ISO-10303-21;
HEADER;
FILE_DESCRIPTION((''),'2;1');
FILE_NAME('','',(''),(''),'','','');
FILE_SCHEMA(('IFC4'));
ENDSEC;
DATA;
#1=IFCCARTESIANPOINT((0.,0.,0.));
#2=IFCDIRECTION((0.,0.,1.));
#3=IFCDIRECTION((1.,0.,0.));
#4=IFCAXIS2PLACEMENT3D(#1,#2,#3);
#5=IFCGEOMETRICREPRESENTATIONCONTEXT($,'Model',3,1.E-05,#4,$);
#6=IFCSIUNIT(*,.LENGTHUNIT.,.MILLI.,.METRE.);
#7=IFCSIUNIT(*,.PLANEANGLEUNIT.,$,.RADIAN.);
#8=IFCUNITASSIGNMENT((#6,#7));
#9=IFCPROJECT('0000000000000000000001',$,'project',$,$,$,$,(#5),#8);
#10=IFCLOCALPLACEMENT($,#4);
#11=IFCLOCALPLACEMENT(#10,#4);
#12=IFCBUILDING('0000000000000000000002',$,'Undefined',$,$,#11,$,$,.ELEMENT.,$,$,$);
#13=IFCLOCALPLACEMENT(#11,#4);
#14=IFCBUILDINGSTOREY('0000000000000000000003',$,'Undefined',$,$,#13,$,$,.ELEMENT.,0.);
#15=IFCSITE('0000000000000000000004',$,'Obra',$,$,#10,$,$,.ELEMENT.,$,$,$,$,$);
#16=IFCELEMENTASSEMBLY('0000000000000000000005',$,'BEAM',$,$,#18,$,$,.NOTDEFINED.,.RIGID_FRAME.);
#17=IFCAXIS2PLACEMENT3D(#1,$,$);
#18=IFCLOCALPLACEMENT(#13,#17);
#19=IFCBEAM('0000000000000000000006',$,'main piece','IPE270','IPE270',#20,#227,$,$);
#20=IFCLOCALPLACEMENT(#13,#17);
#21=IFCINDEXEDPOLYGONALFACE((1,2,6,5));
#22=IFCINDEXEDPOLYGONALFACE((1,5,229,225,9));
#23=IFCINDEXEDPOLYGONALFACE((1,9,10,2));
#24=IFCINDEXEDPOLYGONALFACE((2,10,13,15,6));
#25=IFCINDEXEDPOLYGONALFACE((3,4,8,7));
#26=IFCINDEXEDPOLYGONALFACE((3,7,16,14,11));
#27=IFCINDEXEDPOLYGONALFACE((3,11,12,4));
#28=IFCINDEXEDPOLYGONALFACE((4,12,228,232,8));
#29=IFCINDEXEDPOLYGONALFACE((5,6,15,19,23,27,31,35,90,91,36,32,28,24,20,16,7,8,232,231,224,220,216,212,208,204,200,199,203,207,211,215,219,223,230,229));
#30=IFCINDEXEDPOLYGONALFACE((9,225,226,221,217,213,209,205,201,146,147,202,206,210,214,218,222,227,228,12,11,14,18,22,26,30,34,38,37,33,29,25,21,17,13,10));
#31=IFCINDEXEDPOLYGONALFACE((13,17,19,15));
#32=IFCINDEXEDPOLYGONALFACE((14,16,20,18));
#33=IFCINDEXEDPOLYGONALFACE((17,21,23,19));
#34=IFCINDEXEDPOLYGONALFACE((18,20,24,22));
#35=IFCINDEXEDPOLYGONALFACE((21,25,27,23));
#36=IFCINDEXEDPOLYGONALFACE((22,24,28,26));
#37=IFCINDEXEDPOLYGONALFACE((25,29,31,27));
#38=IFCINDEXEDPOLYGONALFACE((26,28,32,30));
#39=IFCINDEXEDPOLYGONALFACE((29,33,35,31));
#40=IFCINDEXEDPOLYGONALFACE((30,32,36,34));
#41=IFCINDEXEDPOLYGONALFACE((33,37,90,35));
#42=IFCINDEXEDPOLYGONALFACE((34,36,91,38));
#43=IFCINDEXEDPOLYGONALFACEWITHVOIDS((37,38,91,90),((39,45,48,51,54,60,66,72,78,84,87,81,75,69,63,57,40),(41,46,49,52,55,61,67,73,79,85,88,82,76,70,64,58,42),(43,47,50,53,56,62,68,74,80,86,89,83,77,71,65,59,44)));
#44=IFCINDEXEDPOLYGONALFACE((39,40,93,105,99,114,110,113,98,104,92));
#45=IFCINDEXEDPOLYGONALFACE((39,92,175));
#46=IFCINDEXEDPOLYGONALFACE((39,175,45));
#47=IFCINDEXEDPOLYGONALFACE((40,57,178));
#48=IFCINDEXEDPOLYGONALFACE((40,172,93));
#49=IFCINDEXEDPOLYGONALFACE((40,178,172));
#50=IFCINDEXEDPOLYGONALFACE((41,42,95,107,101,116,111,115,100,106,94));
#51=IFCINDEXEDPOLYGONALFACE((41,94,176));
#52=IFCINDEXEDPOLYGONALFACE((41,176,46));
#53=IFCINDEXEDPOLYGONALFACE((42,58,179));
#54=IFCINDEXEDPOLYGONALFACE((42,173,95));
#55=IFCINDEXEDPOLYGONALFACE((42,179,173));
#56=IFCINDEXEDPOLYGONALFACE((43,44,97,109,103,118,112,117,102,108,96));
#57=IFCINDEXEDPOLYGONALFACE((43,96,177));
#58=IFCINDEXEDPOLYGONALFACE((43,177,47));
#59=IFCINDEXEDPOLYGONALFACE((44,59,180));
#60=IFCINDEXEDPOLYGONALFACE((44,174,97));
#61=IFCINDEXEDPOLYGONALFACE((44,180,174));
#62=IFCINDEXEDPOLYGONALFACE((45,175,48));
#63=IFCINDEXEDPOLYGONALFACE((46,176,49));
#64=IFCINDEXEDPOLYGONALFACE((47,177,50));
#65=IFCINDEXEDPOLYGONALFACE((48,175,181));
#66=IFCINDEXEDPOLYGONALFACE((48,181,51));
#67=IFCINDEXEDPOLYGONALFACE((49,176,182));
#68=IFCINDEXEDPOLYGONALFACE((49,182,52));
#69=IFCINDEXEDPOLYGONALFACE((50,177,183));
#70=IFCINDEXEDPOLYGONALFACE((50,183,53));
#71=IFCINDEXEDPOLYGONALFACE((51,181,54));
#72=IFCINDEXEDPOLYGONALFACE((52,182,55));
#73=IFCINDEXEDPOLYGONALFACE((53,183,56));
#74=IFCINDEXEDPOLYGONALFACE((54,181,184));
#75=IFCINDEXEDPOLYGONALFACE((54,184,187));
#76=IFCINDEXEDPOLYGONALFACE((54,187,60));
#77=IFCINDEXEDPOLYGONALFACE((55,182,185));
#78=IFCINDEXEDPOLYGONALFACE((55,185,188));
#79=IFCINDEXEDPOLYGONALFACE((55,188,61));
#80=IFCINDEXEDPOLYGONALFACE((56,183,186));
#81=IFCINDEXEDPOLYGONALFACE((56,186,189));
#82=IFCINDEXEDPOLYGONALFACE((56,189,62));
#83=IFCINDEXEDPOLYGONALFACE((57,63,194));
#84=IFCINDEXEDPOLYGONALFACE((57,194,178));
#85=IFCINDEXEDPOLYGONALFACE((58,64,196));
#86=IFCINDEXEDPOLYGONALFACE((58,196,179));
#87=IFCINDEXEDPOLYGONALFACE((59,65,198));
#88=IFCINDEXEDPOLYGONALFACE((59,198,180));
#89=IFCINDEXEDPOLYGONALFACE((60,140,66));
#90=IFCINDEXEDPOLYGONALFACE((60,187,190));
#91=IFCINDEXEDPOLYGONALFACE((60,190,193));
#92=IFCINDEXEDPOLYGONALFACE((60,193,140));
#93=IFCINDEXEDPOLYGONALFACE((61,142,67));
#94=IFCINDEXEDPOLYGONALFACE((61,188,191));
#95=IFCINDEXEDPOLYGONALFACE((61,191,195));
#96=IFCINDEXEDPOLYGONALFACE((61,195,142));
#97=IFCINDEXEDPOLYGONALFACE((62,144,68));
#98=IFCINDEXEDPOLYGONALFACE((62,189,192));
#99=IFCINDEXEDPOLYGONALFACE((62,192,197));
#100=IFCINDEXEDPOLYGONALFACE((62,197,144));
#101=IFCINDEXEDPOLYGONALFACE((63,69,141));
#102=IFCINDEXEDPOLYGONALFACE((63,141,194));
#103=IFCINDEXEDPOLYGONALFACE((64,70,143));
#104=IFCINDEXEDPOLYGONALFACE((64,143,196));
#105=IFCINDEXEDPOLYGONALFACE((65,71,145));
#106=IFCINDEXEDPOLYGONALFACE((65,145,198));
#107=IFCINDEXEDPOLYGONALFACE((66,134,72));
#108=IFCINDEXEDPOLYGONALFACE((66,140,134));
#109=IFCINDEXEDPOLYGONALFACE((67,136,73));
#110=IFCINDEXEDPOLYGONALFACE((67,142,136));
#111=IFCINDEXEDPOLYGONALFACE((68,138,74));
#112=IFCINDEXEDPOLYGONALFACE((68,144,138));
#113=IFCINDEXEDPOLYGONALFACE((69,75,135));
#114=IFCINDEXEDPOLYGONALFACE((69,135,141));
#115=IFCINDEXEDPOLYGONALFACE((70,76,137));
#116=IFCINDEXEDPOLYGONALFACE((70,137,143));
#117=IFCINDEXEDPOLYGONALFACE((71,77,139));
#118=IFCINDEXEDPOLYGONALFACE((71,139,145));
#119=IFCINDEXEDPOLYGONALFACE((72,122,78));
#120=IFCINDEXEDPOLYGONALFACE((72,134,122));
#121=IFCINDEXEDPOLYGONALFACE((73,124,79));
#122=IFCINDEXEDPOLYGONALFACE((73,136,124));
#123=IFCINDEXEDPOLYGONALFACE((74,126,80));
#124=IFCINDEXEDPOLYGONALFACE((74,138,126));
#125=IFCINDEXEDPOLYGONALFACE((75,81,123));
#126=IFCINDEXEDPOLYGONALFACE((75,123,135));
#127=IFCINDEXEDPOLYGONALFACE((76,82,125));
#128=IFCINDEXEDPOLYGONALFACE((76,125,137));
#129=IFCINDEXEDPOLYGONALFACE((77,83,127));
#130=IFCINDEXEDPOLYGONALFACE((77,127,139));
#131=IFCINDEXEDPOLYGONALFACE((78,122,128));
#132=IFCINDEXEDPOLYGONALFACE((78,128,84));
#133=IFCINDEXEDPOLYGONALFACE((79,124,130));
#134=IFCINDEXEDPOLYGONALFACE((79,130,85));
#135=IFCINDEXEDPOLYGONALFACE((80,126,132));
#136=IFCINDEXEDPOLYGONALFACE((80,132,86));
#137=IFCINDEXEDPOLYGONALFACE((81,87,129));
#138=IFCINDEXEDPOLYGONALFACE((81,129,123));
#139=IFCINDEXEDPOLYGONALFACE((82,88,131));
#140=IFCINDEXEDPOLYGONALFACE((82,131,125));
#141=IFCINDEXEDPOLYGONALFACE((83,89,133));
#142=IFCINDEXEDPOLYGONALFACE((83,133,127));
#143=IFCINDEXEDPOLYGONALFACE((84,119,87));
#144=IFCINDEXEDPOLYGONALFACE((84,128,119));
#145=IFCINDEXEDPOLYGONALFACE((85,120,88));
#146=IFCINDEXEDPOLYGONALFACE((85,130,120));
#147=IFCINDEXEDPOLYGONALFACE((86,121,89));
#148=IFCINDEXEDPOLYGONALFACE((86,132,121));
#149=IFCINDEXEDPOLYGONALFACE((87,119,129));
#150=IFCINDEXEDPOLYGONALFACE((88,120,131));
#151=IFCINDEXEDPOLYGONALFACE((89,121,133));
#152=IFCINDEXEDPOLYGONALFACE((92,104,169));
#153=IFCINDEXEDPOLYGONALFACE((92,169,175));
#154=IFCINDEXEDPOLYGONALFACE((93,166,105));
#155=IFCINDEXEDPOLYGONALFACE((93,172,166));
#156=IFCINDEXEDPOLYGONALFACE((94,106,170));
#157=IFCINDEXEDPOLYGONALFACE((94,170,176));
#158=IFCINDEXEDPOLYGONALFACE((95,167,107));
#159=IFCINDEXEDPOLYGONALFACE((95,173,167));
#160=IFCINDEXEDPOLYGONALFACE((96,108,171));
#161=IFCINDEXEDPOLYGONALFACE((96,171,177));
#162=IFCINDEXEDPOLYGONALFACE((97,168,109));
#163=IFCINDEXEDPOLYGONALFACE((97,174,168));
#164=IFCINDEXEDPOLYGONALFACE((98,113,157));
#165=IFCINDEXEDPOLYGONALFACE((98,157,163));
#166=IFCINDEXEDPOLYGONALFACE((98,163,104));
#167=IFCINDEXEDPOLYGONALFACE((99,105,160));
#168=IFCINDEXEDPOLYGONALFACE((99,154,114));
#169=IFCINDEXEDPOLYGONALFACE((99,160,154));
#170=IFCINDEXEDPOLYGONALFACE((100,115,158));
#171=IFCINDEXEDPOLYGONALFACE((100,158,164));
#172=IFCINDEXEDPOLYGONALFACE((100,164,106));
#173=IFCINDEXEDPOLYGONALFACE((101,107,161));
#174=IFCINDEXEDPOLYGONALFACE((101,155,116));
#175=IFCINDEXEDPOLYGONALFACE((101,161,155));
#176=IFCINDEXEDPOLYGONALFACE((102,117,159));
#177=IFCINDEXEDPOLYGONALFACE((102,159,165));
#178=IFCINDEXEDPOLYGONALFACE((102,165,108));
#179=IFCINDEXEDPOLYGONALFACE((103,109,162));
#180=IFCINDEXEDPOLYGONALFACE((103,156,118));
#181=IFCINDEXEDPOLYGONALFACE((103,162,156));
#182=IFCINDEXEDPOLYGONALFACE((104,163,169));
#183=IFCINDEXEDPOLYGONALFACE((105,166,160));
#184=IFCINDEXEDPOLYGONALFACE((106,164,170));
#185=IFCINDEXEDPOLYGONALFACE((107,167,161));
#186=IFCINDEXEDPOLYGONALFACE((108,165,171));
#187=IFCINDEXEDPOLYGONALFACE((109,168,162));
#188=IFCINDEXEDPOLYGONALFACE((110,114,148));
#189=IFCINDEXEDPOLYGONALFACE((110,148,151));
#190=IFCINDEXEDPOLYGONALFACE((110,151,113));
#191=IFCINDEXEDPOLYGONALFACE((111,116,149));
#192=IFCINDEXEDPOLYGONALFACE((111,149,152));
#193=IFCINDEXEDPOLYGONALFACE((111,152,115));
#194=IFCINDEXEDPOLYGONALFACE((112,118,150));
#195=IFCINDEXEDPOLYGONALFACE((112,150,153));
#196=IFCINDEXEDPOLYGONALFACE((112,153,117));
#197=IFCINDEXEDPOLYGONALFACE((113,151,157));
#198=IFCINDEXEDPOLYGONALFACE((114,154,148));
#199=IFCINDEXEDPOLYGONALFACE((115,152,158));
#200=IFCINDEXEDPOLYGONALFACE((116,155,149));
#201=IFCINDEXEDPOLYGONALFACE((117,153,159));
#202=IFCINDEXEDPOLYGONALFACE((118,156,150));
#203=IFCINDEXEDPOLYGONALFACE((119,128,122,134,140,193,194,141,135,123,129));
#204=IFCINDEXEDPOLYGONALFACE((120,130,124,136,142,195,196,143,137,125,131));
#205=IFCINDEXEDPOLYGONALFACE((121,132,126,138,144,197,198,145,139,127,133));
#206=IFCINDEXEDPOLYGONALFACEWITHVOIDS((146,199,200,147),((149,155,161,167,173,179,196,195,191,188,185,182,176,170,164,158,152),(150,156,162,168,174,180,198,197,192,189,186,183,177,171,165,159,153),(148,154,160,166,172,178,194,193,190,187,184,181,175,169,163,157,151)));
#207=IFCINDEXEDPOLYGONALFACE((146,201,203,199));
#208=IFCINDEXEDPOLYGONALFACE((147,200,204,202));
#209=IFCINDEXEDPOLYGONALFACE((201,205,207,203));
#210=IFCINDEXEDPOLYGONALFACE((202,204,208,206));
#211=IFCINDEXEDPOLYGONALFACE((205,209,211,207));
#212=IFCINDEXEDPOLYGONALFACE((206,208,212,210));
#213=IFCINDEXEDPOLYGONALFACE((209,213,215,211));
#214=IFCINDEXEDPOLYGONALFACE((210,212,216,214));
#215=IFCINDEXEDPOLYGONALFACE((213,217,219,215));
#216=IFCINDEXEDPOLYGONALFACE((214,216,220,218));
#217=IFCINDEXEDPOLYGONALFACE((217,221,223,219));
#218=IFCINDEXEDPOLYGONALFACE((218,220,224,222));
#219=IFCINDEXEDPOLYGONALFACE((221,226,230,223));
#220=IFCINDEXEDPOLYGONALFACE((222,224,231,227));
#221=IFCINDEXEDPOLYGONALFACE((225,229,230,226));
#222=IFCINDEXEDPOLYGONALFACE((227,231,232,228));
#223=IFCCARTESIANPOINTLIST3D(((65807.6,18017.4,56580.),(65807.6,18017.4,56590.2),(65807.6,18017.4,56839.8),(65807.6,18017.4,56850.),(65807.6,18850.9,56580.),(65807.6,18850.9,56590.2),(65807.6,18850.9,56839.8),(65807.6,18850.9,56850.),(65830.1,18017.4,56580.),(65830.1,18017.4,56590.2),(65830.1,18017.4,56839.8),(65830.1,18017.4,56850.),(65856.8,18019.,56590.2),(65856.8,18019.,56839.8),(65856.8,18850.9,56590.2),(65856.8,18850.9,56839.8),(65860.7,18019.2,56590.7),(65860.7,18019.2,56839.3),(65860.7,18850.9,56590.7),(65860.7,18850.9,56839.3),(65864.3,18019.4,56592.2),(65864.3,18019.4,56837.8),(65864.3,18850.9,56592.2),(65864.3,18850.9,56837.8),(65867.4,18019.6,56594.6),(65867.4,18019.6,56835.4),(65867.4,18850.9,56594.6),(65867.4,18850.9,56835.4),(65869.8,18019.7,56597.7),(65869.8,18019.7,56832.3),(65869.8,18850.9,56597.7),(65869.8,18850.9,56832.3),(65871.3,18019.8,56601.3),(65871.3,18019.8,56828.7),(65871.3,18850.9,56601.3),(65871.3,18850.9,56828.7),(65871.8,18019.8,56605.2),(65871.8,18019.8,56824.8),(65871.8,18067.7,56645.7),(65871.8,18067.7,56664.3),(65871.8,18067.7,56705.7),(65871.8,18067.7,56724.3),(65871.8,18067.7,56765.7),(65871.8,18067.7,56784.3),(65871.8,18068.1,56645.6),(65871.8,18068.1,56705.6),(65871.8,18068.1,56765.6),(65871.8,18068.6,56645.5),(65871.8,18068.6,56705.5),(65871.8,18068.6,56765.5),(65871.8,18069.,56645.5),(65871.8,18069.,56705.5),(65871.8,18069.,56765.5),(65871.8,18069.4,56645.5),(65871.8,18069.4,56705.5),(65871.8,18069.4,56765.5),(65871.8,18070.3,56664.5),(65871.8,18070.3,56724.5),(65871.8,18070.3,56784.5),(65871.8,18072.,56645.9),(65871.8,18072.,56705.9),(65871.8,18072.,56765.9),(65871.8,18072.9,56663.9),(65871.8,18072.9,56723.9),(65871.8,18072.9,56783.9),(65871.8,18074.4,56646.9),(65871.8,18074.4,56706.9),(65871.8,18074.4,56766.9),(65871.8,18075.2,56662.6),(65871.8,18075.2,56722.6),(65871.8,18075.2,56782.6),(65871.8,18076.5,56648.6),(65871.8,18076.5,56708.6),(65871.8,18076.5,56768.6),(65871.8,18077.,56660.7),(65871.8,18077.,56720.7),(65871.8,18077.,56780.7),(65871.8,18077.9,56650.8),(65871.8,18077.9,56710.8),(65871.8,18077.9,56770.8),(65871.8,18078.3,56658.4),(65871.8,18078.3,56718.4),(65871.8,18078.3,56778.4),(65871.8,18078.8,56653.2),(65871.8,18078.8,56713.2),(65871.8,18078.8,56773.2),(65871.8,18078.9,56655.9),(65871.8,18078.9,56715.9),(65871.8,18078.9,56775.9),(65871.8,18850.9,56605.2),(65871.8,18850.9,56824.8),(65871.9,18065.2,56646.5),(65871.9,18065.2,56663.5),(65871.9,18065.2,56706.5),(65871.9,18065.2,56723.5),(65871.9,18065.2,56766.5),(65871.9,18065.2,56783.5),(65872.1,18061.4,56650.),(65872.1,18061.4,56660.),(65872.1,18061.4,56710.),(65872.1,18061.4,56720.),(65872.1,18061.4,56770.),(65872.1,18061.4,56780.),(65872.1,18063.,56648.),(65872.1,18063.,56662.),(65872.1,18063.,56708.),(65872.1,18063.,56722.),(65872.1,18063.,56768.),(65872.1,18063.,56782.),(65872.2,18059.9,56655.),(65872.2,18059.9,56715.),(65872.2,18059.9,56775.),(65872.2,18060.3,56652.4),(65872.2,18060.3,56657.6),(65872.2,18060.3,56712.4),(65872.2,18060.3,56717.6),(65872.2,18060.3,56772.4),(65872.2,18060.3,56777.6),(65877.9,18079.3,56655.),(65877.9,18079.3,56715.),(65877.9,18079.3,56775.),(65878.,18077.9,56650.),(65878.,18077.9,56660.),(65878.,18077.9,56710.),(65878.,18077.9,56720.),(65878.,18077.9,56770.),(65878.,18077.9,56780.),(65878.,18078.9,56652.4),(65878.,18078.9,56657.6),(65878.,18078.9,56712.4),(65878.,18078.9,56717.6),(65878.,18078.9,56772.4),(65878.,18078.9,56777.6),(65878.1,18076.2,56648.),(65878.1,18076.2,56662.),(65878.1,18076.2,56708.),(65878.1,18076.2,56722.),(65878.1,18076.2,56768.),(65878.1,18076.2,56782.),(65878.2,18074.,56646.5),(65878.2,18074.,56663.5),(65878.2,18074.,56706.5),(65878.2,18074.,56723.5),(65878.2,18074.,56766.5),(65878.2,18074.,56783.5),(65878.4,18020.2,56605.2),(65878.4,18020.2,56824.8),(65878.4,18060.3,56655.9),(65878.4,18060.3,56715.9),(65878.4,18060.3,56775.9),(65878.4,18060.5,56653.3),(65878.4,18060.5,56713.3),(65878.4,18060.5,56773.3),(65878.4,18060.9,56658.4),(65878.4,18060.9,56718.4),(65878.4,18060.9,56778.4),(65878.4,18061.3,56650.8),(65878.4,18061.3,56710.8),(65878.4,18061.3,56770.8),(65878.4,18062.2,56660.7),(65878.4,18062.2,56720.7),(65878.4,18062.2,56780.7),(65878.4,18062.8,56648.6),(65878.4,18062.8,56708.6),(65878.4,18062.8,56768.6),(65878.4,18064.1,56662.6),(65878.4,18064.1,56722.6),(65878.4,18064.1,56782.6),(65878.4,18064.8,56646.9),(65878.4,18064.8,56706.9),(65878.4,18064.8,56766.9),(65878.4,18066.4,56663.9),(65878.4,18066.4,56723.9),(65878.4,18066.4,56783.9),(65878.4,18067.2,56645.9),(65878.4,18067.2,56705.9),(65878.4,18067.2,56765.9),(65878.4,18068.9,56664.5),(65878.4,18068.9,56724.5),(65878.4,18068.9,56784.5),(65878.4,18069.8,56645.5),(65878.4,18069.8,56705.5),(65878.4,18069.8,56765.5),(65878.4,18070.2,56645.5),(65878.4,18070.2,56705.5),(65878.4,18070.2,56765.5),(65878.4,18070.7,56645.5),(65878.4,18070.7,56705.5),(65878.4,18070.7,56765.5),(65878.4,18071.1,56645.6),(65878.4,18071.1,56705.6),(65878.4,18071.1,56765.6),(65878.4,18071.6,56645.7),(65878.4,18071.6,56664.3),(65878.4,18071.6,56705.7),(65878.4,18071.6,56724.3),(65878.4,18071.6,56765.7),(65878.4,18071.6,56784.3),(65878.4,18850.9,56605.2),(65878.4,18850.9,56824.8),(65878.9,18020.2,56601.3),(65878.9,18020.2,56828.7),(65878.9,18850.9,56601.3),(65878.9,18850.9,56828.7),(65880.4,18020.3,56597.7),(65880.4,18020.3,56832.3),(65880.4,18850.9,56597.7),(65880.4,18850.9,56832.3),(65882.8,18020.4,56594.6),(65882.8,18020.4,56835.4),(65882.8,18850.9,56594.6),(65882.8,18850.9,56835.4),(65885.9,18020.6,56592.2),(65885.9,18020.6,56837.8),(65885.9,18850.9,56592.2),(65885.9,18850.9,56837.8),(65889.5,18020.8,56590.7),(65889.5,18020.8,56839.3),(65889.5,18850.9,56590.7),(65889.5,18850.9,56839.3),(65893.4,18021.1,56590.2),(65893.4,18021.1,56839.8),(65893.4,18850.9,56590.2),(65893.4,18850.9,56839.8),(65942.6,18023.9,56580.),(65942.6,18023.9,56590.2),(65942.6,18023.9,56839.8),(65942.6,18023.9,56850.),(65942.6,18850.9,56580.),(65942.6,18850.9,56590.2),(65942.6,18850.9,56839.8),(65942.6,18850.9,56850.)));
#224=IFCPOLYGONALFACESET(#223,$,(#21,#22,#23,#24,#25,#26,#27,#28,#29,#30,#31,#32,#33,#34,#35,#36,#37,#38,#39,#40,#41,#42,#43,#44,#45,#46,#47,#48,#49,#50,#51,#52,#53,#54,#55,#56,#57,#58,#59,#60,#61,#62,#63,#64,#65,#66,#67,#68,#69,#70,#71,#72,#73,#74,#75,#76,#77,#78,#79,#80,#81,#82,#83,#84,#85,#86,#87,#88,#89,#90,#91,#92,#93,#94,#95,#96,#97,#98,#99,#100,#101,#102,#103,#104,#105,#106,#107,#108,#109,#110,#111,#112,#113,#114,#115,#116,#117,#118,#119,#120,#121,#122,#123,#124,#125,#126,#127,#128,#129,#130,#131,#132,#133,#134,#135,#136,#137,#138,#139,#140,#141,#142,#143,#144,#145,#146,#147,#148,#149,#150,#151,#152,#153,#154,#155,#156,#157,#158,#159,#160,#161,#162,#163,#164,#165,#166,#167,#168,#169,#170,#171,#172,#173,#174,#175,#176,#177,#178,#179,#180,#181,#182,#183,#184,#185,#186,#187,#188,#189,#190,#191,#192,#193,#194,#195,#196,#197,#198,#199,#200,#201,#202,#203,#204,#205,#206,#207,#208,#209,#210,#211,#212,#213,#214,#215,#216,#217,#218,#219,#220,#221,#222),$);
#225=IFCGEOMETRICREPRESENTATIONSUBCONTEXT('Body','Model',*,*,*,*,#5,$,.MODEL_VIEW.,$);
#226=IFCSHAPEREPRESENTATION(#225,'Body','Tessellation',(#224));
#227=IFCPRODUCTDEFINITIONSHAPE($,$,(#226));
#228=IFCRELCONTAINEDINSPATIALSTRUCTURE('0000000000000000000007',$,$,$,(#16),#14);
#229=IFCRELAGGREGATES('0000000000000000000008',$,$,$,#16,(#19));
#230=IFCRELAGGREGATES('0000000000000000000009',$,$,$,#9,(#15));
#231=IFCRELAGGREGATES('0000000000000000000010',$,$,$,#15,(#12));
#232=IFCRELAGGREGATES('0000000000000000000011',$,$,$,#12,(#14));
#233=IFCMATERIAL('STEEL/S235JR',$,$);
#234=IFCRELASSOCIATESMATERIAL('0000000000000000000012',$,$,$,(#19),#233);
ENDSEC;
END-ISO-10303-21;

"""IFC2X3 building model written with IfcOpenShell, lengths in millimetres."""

from ifc_helpers import new_model, si_unit, frame, origin_with_axes, origin_2d_with_axis, place, context, subcontext, project, spatial, circle, i_section, extrude, clip, halfspace, source, transform, mapped, material, element, aggregate, save


model = new_model("IFC2X3")

# Units and contexts
model_context = context("Model", 3, precision=1e-05, world=origin_with_axes())
body_context = subcontext(model_context, "Body", "Model", "MODEL_VIEW")
ifc_project = project(units=[si_unit("LENGTHUNIT", "METRE", prefix="MILLI"), si_unit("PLANEANGLEUNIT", "RADIAN")], contexts=[model_context])

# Site, building, storey
site_placement = place(None, origin_with_axes())
site = spatial("IfcSite", under=ifc_project, at=site_placement, Name="Obra", CompositionType="ELEMENT")
building_placement = place(site_placement, origin_with_axes())
building = spatial("IfcBuilding", under=site, at=building_placement, Name="Undefined", CompositionType="ELEMENT")
storey_placement = place(building_placement, origin_with_axes())
storey = spatial("IfcBuildingStorey", under=building, at=storey_placement, Name="Undefined", CompositionType="ELEMENT", Elevation=0.0)

# Shared definitions
ifc_material_1 = material(Name="STEEL/S235JR")

# Element assembly, beam, opening
assembly_1_placement = place(storey_placement, origin_with_axes())
assembly_1 = element("IfcElementAssembly", 1, at=assembly_1_placement, inside=storey, Name="BEAM", AssemblyPlace="NOTDEFINED", PredefinedType="RIGID_FRAME")
beam_1_placement = place(assembly_1_placement, frame((65875.1, 18017.4, 56715.0), z_axis=(0.0, 0.0, 1.0), x_axis=(0.000007, 1.0, 0.0)))
beam_1 = element("IfcBeam", 2, at=beam_1_placement, material=ifc_material_1, Name="main piece", Description="IPE270", ObjectType="IPE270", context=body_context, shape_type="Clipping", body=[
    clip(extrude(i_section(OverallWidth=135.0, OverallDepth=270.0, WebThickness=6.6, FlangeThickness=10.2, FilletRadius=15.0, at=origin_2d_with_axis()), frame((833.4, 0.0, 0.0), z_axis=(-1.0, 0.0, 0.0), x_axis=(0.0, -1.0, 0.0)), (0.0, 0.0, 1.0), 833.4), halfspace(frame((-2.5, 89.1, -120.0), z_axis=(-0.998367, -0.057133, 0.0), x_axis=(0.0, 0.0, 1.0)), False)),
])
shared_shape_1 = source(origin_with_axes(), body_context, "Body", "SweptSolid", [
    extrude(circle(Radius=9.5, at=origin_2d_with_axis()), frame((0.0, -35.4, 0.0), z_axis=(0.0, 1.0, 0.0), x_axis=(1.0, 0.0, 0.0)), (0.0, 0.0, 1.0), 6.8),
])
opening_1_placement = place(assembly_1_placement, frame((65846.0, 18017.9, 56835.0), z_axis=(-0.057107, 0.998368, 0.0), x_axis=(0.0, 0.0, -1.0)))
element("IfcOpeningElement", 3, at=opening_1_placement, cuts=beam_1, ObjectType="Opening", context=body_context, shape_type="MappedRepresentation", body=[
    mapped(shared_shape_1, transform((60.0, 0.0, 50.0))),
    mapped(shared_shape_1, transform((120.0, 0.0, 50.0))),
    mapped(shared_shape_1, transform((180.0, 0.0, 50.0))),
])
aggregate(assembly_1, [beam_1])

save(model, "model.ifc")
